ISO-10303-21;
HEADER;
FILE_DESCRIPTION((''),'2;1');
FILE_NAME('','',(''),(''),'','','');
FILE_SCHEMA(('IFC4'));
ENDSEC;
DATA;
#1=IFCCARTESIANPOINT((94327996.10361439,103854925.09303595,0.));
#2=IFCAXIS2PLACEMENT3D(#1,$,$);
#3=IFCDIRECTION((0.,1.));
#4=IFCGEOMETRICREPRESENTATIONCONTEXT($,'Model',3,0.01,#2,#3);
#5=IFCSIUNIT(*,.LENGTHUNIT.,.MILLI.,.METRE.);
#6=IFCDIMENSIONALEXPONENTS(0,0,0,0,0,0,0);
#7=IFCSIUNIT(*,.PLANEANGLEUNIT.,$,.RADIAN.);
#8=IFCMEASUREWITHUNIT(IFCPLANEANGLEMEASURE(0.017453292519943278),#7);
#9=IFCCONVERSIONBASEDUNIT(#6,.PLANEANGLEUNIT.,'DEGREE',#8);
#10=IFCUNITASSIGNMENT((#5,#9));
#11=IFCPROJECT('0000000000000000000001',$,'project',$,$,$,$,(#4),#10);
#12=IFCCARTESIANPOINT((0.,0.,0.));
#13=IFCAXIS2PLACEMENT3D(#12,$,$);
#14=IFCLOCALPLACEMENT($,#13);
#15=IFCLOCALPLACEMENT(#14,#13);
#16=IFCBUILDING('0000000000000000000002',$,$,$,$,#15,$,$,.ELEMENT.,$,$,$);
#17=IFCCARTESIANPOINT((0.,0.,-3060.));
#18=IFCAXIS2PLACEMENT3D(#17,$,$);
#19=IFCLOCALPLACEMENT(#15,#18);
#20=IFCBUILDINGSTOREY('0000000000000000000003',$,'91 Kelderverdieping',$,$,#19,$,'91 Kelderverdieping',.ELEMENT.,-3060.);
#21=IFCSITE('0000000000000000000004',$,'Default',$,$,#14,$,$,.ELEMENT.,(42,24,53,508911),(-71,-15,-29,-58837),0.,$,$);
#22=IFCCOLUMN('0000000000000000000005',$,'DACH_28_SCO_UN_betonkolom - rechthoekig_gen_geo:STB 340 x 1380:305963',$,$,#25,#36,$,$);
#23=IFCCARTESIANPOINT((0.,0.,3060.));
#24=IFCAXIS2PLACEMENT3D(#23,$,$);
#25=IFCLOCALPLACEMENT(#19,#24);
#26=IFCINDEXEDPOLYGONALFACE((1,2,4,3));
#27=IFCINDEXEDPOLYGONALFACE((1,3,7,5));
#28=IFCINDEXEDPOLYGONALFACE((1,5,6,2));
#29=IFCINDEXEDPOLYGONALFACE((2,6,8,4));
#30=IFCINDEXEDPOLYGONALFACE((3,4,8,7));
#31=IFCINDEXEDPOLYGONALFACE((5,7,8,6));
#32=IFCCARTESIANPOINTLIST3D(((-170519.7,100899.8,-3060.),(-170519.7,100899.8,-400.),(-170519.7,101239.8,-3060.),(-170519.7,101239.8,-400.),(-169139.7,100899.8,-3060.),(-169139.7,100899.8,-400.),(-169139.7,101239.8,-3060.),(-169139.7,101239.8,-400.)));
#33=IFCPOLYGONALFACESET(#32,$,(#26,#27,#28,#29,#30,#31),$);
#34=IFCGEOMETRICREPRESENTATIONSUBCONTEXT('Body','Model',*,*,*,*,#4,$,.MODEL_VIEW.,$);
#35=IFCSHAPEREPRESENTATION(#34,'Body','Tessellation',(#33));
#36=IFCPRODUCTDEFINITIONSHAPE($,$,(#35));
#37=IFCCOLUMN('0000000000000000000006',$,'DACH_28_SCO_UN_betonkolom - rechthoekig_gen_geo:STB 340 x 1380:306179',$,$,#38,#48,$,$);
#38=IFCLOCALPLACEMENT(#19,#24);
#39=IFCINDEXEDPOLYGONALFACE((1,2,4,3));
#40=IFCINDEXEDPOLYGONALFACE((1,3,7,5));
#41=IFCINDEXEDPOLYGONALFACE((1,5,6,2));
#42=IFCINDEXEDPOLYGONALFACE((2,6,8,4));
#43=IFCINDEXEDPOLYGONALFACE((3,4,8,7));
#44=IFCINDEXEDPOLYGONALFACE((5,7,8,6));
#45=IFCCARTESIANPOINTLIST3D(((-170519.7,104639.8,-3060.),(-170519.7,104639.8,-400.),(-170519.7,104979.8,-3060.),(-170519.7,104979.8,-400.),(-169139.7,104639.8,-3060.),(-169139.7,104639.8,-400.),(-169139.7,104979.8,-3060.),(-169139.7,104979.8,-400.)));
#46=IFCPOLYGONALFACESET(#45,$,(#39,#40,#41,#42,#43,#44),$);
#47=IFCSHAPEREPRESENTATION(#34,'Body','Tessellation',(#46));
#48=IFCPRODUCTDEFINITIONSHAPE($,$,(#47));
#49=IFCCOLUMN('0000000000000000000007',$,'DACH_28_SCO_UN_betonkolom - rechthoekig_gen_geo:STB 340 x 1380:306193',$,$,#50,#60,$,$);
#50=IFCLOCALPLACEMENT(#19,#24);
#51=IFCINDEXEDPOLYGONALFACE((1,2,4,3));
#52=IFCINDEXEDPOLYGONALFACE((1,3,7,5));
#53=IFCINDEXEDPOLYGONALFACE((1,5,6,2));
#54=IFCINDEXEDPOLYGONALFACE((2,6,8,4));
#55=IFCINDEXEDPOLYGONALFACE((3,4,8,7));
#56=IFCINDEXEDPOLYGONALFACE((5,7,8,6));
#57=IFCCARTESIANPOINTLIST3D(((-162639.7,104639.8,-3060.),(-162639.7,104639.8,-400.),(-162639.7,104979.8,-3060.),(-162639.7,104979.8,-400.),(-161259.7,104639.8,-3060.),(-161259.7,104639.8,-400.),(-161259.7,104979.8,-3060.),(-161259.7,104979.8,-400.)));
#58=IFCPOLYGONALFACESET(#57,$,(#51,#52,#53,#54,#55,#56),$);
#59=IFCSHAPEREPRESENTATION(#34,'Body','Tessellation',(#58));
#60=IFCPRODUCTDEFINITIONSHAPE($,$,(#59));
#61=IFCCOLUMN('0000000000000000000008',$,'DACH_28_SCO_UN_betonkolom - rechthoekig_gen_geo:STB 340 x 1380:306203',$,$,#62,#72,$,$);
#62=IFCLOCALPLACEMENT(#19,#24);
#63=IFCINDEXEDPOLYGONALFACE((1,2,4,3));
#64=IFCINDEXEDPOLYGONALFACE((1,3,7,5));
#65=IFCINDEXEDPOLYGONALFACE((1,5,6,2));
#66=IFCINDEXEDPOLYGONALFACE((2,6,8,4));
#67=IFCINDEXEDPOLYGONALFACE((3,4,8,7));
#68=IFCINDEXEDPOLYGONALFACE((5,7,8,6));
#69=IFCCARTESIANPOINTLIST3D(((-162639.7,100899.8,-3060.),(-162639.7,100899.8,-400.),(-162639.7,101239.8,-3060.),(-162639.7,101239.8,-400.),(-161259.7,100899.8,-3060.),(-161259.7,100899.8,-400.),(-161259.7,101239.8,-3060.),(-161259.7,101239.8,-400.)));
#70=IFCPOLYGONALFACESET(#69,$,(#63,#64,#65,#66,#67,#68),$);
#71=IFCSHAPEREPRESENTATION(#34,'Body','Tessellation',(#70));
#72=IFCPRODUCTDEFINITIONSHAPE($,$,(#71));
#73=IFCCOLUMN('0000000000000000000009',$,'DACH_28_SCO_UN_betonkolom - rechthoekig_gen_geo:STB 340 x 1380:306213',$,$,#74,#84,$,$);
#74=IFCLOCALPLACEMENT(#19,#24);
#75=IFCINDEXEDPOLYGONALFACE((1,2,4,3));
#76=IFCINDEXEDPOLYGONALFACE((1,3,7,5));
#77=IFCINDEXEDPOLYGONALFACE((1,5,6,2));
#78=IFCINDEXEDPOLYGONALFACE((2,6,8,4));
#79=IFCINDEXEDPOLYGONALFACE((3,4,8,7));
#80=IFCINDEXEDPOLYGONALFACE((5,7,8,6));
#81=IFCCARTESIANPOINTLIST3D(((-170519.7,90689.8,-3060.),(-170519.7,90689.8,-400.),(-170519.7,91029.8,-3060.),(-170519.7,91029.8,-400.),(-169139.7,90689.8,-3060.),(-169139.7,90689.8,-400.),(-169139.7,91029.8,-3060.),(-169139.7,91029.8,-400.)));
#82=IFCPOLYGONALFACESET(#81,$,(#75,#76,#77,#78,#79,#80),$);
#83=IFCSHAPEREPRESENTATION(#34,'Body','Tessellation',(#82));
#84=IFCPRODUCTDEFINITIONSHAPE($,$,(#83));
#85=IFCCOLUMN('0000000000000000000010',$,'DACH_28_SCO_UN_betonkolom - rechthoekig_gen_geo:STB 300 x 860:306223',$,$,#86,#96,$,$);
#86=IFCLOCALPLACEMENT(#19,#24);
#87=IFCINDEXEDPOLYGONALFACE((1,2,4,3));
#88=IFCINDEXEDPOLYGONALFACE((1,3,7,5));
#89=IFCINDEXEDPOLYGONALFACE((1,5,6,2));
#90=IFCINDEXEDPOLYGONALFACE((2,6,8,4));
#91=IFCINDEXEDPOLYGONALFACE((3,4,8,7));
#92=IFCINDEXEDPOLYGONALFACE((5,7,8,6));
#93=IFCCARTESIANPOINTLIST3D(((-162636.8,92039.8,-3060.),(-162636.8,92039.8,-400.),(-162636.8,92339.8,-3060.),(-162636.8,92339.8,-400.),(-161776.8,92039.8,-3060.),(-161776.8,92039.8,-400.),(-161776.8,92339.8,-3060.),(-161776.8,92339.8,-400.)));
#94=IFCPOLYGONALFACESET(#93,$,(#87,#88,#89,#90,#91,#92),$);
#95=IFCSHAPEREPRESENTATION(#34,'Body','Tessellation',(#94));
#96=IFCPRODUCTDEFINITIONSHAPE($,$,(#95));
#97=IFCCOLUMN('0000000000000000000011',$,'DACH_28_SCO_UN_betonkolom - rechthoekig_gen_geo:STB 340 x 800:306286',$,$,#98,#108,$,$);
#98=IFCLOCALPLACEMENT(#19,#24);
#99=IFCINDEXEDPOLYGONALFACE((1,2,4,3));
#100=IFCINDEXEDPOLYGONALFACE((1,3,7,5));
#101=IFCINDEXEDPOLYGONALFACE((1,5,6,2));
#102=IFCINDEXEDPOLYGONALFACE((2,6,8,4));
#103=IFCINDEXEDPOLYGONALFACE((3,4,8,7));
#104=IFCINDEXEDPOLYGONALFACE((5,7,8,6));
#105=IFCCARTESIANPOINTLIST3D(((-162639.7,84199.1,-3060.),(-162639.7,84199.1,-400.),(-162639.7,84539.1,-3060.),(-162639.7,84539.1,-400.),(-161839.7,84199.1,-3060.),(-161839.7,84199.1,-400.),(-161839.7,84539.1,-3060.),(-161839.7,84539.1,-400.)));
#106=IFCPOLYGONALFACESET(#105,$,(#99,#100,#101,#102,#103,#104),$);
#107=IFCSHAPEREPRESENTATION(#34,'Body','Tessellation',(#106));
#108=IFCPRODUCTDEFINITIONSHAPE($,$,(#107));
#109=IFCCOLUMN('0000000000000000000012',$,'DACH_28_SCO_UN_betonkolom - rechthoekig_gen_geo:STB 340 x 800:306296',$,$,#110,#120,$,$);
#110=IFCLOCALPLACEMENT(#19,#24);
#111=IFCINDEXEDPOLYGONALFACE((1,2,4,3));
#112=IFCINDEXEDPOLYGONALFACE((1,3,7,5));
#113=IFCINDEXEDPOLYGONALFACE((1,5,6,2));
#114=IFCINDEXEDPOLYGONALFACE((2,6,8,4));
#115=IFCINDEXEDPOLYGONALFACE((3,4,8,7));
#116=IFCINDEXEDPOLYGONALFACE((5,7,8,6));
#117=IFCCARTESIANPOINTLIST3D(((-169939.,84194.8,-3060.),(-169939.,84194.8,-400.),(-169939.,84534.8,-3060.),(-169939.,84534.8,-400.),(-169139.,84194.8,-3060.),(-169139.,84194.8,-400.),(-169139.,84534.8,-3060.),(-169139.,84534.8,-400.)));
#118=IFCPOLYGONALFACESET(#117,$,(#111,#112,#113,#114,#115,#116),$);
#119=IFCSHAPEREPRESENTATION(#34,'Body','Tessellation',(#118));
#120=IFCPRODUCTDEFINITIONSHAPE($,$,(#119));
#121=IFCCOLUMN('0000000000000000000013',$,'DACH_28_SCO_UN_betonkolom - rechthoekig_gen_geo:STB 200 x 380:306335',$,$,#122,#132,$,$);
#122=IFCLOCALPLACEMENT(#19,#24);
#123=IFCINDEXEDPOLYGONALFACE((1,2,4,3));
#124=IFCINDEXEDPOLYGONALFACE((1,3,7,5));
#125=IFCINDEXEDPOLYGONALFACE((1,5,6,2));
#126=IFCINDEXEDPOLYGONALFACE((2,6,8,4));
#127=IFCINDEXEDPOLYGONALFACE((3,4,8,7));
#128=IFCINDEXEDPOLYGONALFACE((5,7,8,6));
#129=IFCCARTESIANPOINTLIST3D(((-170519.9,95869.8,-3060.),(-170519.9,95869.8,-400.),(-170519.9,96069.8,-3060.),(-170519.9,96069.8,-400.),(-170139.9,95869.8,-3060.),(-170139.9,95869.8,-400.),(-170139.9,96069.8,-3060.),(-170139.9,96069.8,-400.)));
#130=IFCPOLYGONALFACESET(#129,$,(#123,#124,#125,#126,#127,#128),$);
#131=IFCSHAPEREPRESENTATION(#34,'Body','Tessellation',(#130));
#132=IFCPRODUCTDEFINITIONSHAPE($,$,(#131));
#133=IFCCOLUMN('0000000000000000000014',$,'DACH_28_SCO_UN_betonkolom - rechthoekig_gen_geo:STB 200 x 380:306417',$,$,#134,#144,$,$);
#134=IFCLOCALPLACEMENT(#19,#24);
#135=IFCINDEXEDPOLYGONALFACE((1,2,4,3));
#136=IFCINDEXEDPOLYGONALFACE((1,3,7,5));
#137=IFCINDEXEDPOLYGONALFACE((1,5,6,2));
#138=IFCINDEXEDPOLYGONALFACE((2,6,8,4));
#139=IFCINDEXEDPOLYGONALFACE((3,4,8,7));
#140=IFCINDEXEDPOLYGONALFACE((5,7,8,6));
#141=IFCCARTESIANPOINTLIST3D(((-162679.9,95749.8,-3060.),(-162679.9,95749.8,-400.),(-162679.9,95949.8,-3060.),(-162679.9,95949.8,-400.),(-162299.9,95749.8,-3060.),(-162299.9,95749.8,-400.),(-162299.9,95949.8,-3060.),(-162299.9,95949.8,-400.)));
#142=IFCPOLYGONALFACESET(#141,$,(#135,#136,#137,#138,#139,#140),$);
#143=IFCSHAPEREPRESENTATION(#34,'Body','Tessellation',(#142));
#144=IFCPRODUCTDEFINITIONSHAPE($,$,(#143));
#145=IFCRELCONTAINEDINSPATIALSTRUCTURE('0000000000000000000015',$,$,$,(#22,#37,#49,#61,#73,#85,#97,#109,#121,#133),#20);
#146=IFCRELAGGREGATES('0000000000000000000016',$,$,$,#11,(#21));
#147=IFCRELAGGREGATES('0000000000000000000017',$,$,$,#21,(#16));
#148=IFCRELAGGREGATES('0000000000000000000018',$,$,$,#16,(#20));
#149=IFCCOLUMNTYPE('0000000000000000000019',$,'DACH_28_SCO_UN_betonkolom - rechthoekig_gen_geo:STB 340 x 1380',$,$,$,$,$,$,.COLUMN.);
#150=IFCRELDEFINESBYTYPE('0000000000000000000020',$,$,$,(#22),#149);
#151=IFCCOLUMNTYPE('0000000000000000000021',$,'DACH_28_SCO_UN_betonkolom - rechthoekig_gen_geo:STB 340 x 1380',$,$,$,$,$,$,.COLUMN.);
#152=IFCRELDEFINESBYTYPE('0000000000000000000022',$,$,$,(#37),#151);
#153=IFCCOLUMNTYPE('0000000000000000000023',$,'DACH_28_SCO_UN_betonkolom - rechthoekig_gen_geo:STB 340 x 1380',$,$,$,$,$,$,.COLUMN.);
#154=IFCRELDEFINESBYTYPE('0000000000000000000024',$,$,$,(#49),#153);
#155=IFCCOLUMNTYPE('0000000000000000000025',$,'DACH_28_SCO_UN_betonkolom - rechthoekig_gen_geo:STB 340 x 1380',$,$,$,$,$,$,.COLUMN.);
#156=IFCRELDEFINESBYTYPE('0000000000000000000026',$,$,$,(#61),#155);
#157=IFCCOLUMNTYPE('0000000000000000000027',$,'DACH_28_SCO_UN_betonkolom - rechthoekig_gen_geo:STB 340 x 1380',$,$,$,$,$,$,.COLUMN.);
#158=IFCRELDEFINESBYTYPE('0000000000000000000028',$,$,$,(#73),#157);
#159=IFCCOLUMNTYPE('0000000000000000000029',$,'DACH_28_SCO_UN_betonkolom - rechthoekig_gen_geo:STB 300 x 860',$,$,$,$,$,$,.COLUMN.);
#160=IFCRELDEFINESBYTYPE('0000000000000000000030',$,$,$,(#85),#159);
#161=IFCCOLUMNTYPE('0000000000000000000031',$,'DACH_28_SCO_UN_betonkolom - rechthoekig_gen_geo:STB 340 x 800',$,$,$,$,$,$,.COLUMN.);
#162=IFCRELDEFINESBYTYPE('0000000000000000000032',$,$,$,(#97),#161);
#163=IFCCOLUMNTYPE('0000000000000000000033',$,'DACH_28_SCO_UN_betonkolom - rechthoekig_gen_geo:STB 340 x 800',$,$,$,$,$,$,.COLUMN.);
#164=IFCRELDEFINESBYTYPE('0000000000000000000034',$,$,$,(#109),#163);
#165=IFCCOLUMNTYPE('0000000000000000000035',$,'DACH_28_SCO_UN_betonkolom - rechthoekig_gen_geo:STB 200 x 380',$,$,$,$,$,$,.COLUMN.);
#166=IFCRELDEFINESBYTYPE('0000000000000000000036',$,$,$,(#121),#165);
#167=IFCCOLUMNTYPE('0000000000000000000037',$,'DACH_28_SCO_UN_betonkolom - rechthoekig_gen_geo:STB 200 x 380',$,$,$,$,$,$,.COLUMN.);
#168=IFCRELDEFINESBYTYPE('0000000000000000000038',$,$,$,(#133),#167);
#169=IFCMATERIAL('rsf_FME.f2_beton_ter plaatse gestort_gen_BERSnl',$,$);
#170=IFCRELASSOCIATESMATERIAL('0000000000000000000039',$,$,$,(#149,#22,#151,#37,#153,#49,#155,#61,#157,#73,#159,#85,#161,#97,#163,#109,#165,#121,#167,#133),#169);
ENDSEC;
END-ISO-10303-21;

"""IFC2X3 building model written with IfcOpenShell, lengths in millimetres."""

from ifc_helpers import new_model, entity, si_unit, converted_unit, direction, frame, frame_2d, origin, origin_2d_with_axis, place, context, subcontext, project, spatial, rectangle, extrude, source, transform, mapped, material, type_object, type_shapes, element, save


model = new_model("IFC2X3")

# Units and contexts
model_context = context("Model", 3, precision=0.01, world=frame((94327996.10361439, 103854925.09303595, 0.0)), true_north=direction((0.0, 1.0)))
body_context = subcontext(model_context, "Body", "Model", "MODEL_VIEW")
ifc_project = project(units=[si_unit("LENGTHUNIT", "METRE", prefix="MILLI"), converted_unit("PLANEANGLEUNIT", "DEGREE", entity("IfcPlaneAngleMeasure", 0.017453292519943278), si_unit("PLANEANGLEUNIT", "RADIAN"), dimensions=[0, 0, 0, 0, 0, 0, 0])], contexts=[model_context])

# Site, building, storey
site_placement = place(None, origin())
site = spatial("IfcSite", under=ifc_project, at=site_placement, Name="Default", CompositionType="ELEMENT", RefLatitude=(42, 24, 53, 508911), RefLongitude=(-71, -15, -29, -58837), RefElevation=0.0)
building_placement = place(site_placement, origin())
building = spatial("IfcBuilding", under=site, at=building_placement, CompositionType="ELEMENT")
storey_placement = place(building_placement, frame((0.0, 0.0, -3060.0)))
storey = spatial("IfcBuildingStorey", under=building, at=storey_placement, Name="91 Kelderverdieping", LongName="91 Kelderverdieping", CompositionType="ELEMENT", Elevation=-3060.0)

# Columns
ifc_material_1 = material(Name="rsf_FME.f2_beton_ter plaatse gestort_gen_BERSnl")
column_type_1 = type_object("IfcColumnType", Name="DACH_28_SCO_UN_betonkolom - rechthoekig_gen_geo:STB 340 x 1380", PredefinedType="COLUMN", material=ifc_material_1)
shared_shape_1 = source(origin(), body_context, "Body", "SweptSolid", [
    extrude(rectangle(XDim=1380.0, YDim=340.0, at=frame_2d((0.0, 0.0), x_axis=(1.0, 0.0))), frame((-169829.7, 101069.8, -3060.0), z_axis=(0.0, 0.0, 1.0), x_axis=(-1.0, 0.0, 0.0)), (0.0, 0.0, 1.0), 2660.0),
])
type_shapes(column_type_1, [shared_shape_1])
column_1_placement = place(storey_placement, frame((0.0, 0.0, 3060.0)))
element("IfcColumn", 1, at=column_1_placement, inside=storey, type_object=column_type_1, material=ifc_material_1, Name="DACH_28_SCO_UN_betonkolom - rechthoekig_gen_geo:STB 340 x 1380:305963", context=body_context, shape_type="MappedRepresentation", body=[
    mapped(shared_shape_1, transform((0.0, 0.0, 0.0), scale=1.0)),
])
column_type_2 = type_object("IfcColumnType", Name="DACH_28_SCO_UN_betonkolom - rechthoekig_gen_geo:STB 340 x 1380", PredefinedType="COLUMN", material=ifc_material_1)
shared_shape_2 = source(origin(), body_context, "Body", "SweptSolid", [
    extrude(rectangle(XDim=1380.0, YDim=340.0, at=frame_2d((0.0, 0.0), x_axis=(1.0, 0.0))), frame((-169829.7, 104809.8, -3060.0), z_axis=(0.0, 0.0, 1.0), x_axis=(-1.0, 0.0, 0.0)), (0.0, 0.0, 1.0), 2660.0),
])
type_shapes(column_type_2, [shared_shape_2])
column_2_placement = place(storey_placement, frame((0.0, 0.0, 3060.0)))
element("IfcColumn", 2, at=column_2_placement, inside=storey, type_object=column_type_2, material=ifc_material_1, Name="DACH_28_SCO_UN_betonkolom - rechthoekig_gen_geo:STB 340 x 1380:306179", context=body_context, shape_type="MappedRepresentation", body=[
    mapped(shared_shape_2, transform((0.0, 0.0, 0.0), scale=1.0)),
])
column_type_3 = type_object("IfcColumnType", Name="DACH_28_SCO_UN_betonkolom - rechthoekig_gen_geo:STB 340 x 1380", PredefinedType="COLUMN", material=ifc_material_1)
shared_shape_3 = source(origin(), body_context, "Body", "SweptSolid", [
    extrude(rectangle(XDim=1380.0, YDim=340.0, at=frame_2d((0.0, 0.0), x_axis=(1.0, 0.0))), frame((-161949.7, 104809.8, -3060.0), z_axis=(0.0, 0.0, 1.0), x_axis=(-1.0, 0.0, 0.0)), (0.0, 0.0, 1.0), 2660.0),
])
type_shapes(column_type_3, [shared_shape_3])
column_3_placement = place(storey_placement, frame((0.0, 0.0, 3060.0)))
element("IfcColumn", 3, at=column_3_placement, inside=storey, type_object=column_type_3, material=ifc_material_1, Name="DACH_28_SCO_UN_betonkolom - rechthoekig_gen_geo:STB 340 x 1380:306193", context=body_context, shape_type="MappedRepresentation", body=[
    mapped(shared_shape_3, transform((0.0, 0.0, 0.0), scale=1.0)),
])
column_type_4 = type_object("IfcColumnType", Name="DACH_28_SCO_UN_betonkolom - rechthoekig_gen_geo:STB 340 x 1380", PredefinedType="COLUMN", material=ifc_material_1)
shared_shape_4 = source(origin(), body_context, "Body", "SweptSolid", [
    extrude(rectangle(XDim=1380.0, YDim=340.0, at=frame_2d((0.0, 0.0), x_axis=(1.0, 0.0))), frame((-161949.7, 101069.8, -3060.0), z_axis=(0.0, 0.0, 1.0), x_axis=(-1.0, 0.0, 0.0)), (0.0, 0.0, 1.0), 2660.0),
])
type_shapes(column_type_4, [shared_shape_4])
column_4_placement = place(storey_placement, frame((0.0, 0.0, 3060.0)))
element("IfcColumn", 4, at=column_4_placement, inside=storey, type_object=column_type_4, material=ifc_material_1, Name="DACH_28_SCO_UN_betonkolom - rechthoekig_gen_geo:STB 340 x 1380:306203", context=body_context, shape_type="MappedRepresentation", body=[
    mapped(shared_shape_4, transform((0.0, 0.0, 0.0), scale=1.0)),
])
column_type_5 = type_object("IfcColumnType", Name="DACH_28_SCO_UN_betonkolom - rechthoekig_gen_geo:STB 340 x 1380", PredefinedType="COLUMN", material=ifc_material_1)
shared_shape_5 = source(origin(), body_context, "Body", "SweptSolid", [
    extrude(rectangle(XDim=1380.0, YDim=340.0, at=frame_2d((0.0, 0.0), x_axis=(1.0, 0.0))), frame((-169829.7, 90859.8, -3060.0), z_axis=(0.0, 0.0, 1.0), x_axis=(-1.0, 0.0, 0.0)), (0.0, 0.0, 1.0), 2660.0),
])
type_shapes(column_type_5, [shared_shape_5])
column_5_placement = place(storey_placement, frame((0.0, 0.0, 3060.0)))
element("IfcColumn", 5, at=column_5_placement, inside=storey, type_object=column_type_5, material=ifc_material_1, Name="DACH_28_SCO_UN_betonkolom - rechthoekig_gen_geo:STB 340 x 1380:306213", context=body_context, shape_type="MappedRepresentation", body=[
    mapped(shared_shape_5, transform((0.0, 0.0, 0.0), scale=1.0)),
])
column_type_6 = type_object("IfcColumnType", Name="DACH_28_SCO_UN_betonkolom - rechthoekig_gen_geo:STB 300 x 860", PredefinedType="COLUMN", material=ifc_material_1)
shared_shape_6 = source(origin(), body_context, "Body", "SweptSolid", [
    extrude(rectangle(XDim=860.0, YDim=300.0, at=origin_2d_with_axis()), frame((-162206.8, 92189.8, -3060.0), z_axis=(0.0, 0.0, 1.0), x_axis=(-1.0, 0.0, 0.0)), (0.0, 0.0, 1.0), 2660.0),
])
type_shapes(column_type_6, [shared_shape_6])
column_6_placement = place(storey_placement, frame((0.0, 0.0, 3060.0)))
element("IfcColumn", 6, at=column_6_placement, inside=storey, type_object=column_type_6, material=ifc_material_1, Name="DACH_28_SCO_UN_betonkolom - rechthoekig_gen_geo:STB 300 x 860:306223", context=body_context, shape_type="MappedRepresentation", body=[
    mapped(shared_shape_6, transform((0.0, 0.0, 0.0), scale=1.0)),
])
column_type_7 = type_object("IfcColumnType", Name="DACH_28_SCO_UN_betonkolom - rechthoekig_gen_geo:STB 340 x 800", PredefinedType="COLUMN", material=ifc_material_1)
shared_shape_7 = source(origin(), body_context, "Body", "SweptSolid", [
    extrude(rectangle(XDim=800.0, YDim=340.0, at=frame_2d((0.0, 0.0), x_axis=(1.0, 0.0))), frame((-162239.7, 84369.1, -3060.0), z_axis=(0.0, 0.0, 1.0), x_axis=(-1.0, 0.0, 0.0)), (0.0, 0.0, 1.0), 2660.0),
])
type_shapes(column_type_7, [shared_shape_7])
column_7_placement = place(storey_placement, frame((0.0, 0.0, 3060.0)))
element("IfcColumn", 7, at=column_7_placement, inside=storey, type_object=column_type_7, material=ifc_material_1, Name="DACH_28_SCO_UN_betonkolom - rechthoekig_gen_geo:STB 340 x 800:306286", context=body_context, shape_type="MappedRepresentation", body=[
    mapped(shared_shape_7, transform((0.0, 0.0, 0.0), scale=1.0)),
])
column_type_8 = type_object("IfcColumnType", Name="DACH_28_SCO_UN_betonkolom - rechthoekig_gen_geo:STB 340 x 800", PredefinedType="COLUMN", material=ifc_material_1)
shared_shape_8 = source(origin(), body_context, "Body", "SweptSolid", [
    extrude(rectangle(XDim=800.0, YDim=340.0, at=frame_2d((0.0, 0.0), x_axis=(1.0, 0.0))), frame((-169539.0, 84364.8, -3060.0), z_axis=(0.0, 0.0, 1.0), x_axis=(-1.0, 0.0, 0.0)), (0.0, 0.0, 1.0), 2660.0),
])
type_shapes(column_type_8, [shared_shape_8])
column_8_placement = place(storey_placement, frame((0.0, 0.0, 3060.0)))
element("IfcColumn", 8, at=column_8_placement, inside=storey, type_object=column_type_8, material=ifc_material_1, Name="DACH_28_SCO_UN_betonkolom - rechthoekig_gen_geo:STB 340 x 800:306296", context=body_context, shape_type="MappedRepresentation", body=[
    mapped(shared_shape_8, transform((0.0, 0.0, 0.0), scale=1.0)),
])
column_type_9 = type_object("IfcColumnType", Name="DACH_28_SCO_UN_betonkolom - rechthoekig_gen_geo:STB 200 x 380", PredefinedType="COLUMN", material=ifc_material_1)
shared_shape_9 = source(origin(), body_context, "Body", "SweptSolid", [
    extrude(rectangle(XDim=380.0, YDim=200.0, at=frame_2d((0.0, 0.0), x_axis=(1.0, 0.0))), frame((-170329.9, 95969.8, -3060.0), z_axis=(0.0, 0.0, 1.0), x_axis=(-1.0, 0.0, 0.0)), (0.0, 0.0, 1.0), 2660.0),
])
type_shapes(column_type_9, [shared_shape_9])
column_9_placement = place(storey_placement, frame((0.0, 0.0, 3060.0)))
element("IfcColumn", 9, at=column_9_placement, inside=storey, type_object=column_type_9, material=ifc_material_1, Name="DACH_28_SCO_UN_betonkolom - rechthoekig_gen_geo:STB 200 x 380:306335", context=body_context, shape_type="MappedRepresentation", body=[
    mapped(shared_shape_9, transform((0.0, 0.0, 0.0), scale=1.0)),
])
column_type_10 = type_object("IfcColumnType", Name="DACH_28_SCO_UN_betonkolom - rechthoekig_gen_geo:STB 200 x 380", PredefinedType="COLUMN", material=ifc_material_1)
shared_shape_10 = source(origin(), body_context, "Body", "SweptSolid", [
    extrude(rectangle(XDim=380.0, YDim=200.0, at=frame_2d((0.0, 0.0), x_axis=(1.0, 0.0))), frame((-162489.9, 95849.8, -3060.0), z_axis=(0.0, 0.0, 1.0), x_axis=(-1.0, 0.0, 0.0)), (0.0, 0.0, 1.0), 2660.0),
])
type_shapes(column_type_10, [shared_shape_10])
column_10_placement = place(storey_placement, frame((0.0, 0.0, 3060.0)))
element("IfcColumn", 10, at=column_10_placement, inside=storey, type_object=column_type_10, material=ifc_material_1, Name="DACH_28_SCO_UN_betonkolom - rechthoekig_gen_geo:STB 200 x 380:306417", context=body_context, shape_type="MappedRepresentation", body=[
    mapped(shared_shape_10, transform((0.0, 0.0, 0.0), scale=1.0)),
])

save(model, "model.ifc")
